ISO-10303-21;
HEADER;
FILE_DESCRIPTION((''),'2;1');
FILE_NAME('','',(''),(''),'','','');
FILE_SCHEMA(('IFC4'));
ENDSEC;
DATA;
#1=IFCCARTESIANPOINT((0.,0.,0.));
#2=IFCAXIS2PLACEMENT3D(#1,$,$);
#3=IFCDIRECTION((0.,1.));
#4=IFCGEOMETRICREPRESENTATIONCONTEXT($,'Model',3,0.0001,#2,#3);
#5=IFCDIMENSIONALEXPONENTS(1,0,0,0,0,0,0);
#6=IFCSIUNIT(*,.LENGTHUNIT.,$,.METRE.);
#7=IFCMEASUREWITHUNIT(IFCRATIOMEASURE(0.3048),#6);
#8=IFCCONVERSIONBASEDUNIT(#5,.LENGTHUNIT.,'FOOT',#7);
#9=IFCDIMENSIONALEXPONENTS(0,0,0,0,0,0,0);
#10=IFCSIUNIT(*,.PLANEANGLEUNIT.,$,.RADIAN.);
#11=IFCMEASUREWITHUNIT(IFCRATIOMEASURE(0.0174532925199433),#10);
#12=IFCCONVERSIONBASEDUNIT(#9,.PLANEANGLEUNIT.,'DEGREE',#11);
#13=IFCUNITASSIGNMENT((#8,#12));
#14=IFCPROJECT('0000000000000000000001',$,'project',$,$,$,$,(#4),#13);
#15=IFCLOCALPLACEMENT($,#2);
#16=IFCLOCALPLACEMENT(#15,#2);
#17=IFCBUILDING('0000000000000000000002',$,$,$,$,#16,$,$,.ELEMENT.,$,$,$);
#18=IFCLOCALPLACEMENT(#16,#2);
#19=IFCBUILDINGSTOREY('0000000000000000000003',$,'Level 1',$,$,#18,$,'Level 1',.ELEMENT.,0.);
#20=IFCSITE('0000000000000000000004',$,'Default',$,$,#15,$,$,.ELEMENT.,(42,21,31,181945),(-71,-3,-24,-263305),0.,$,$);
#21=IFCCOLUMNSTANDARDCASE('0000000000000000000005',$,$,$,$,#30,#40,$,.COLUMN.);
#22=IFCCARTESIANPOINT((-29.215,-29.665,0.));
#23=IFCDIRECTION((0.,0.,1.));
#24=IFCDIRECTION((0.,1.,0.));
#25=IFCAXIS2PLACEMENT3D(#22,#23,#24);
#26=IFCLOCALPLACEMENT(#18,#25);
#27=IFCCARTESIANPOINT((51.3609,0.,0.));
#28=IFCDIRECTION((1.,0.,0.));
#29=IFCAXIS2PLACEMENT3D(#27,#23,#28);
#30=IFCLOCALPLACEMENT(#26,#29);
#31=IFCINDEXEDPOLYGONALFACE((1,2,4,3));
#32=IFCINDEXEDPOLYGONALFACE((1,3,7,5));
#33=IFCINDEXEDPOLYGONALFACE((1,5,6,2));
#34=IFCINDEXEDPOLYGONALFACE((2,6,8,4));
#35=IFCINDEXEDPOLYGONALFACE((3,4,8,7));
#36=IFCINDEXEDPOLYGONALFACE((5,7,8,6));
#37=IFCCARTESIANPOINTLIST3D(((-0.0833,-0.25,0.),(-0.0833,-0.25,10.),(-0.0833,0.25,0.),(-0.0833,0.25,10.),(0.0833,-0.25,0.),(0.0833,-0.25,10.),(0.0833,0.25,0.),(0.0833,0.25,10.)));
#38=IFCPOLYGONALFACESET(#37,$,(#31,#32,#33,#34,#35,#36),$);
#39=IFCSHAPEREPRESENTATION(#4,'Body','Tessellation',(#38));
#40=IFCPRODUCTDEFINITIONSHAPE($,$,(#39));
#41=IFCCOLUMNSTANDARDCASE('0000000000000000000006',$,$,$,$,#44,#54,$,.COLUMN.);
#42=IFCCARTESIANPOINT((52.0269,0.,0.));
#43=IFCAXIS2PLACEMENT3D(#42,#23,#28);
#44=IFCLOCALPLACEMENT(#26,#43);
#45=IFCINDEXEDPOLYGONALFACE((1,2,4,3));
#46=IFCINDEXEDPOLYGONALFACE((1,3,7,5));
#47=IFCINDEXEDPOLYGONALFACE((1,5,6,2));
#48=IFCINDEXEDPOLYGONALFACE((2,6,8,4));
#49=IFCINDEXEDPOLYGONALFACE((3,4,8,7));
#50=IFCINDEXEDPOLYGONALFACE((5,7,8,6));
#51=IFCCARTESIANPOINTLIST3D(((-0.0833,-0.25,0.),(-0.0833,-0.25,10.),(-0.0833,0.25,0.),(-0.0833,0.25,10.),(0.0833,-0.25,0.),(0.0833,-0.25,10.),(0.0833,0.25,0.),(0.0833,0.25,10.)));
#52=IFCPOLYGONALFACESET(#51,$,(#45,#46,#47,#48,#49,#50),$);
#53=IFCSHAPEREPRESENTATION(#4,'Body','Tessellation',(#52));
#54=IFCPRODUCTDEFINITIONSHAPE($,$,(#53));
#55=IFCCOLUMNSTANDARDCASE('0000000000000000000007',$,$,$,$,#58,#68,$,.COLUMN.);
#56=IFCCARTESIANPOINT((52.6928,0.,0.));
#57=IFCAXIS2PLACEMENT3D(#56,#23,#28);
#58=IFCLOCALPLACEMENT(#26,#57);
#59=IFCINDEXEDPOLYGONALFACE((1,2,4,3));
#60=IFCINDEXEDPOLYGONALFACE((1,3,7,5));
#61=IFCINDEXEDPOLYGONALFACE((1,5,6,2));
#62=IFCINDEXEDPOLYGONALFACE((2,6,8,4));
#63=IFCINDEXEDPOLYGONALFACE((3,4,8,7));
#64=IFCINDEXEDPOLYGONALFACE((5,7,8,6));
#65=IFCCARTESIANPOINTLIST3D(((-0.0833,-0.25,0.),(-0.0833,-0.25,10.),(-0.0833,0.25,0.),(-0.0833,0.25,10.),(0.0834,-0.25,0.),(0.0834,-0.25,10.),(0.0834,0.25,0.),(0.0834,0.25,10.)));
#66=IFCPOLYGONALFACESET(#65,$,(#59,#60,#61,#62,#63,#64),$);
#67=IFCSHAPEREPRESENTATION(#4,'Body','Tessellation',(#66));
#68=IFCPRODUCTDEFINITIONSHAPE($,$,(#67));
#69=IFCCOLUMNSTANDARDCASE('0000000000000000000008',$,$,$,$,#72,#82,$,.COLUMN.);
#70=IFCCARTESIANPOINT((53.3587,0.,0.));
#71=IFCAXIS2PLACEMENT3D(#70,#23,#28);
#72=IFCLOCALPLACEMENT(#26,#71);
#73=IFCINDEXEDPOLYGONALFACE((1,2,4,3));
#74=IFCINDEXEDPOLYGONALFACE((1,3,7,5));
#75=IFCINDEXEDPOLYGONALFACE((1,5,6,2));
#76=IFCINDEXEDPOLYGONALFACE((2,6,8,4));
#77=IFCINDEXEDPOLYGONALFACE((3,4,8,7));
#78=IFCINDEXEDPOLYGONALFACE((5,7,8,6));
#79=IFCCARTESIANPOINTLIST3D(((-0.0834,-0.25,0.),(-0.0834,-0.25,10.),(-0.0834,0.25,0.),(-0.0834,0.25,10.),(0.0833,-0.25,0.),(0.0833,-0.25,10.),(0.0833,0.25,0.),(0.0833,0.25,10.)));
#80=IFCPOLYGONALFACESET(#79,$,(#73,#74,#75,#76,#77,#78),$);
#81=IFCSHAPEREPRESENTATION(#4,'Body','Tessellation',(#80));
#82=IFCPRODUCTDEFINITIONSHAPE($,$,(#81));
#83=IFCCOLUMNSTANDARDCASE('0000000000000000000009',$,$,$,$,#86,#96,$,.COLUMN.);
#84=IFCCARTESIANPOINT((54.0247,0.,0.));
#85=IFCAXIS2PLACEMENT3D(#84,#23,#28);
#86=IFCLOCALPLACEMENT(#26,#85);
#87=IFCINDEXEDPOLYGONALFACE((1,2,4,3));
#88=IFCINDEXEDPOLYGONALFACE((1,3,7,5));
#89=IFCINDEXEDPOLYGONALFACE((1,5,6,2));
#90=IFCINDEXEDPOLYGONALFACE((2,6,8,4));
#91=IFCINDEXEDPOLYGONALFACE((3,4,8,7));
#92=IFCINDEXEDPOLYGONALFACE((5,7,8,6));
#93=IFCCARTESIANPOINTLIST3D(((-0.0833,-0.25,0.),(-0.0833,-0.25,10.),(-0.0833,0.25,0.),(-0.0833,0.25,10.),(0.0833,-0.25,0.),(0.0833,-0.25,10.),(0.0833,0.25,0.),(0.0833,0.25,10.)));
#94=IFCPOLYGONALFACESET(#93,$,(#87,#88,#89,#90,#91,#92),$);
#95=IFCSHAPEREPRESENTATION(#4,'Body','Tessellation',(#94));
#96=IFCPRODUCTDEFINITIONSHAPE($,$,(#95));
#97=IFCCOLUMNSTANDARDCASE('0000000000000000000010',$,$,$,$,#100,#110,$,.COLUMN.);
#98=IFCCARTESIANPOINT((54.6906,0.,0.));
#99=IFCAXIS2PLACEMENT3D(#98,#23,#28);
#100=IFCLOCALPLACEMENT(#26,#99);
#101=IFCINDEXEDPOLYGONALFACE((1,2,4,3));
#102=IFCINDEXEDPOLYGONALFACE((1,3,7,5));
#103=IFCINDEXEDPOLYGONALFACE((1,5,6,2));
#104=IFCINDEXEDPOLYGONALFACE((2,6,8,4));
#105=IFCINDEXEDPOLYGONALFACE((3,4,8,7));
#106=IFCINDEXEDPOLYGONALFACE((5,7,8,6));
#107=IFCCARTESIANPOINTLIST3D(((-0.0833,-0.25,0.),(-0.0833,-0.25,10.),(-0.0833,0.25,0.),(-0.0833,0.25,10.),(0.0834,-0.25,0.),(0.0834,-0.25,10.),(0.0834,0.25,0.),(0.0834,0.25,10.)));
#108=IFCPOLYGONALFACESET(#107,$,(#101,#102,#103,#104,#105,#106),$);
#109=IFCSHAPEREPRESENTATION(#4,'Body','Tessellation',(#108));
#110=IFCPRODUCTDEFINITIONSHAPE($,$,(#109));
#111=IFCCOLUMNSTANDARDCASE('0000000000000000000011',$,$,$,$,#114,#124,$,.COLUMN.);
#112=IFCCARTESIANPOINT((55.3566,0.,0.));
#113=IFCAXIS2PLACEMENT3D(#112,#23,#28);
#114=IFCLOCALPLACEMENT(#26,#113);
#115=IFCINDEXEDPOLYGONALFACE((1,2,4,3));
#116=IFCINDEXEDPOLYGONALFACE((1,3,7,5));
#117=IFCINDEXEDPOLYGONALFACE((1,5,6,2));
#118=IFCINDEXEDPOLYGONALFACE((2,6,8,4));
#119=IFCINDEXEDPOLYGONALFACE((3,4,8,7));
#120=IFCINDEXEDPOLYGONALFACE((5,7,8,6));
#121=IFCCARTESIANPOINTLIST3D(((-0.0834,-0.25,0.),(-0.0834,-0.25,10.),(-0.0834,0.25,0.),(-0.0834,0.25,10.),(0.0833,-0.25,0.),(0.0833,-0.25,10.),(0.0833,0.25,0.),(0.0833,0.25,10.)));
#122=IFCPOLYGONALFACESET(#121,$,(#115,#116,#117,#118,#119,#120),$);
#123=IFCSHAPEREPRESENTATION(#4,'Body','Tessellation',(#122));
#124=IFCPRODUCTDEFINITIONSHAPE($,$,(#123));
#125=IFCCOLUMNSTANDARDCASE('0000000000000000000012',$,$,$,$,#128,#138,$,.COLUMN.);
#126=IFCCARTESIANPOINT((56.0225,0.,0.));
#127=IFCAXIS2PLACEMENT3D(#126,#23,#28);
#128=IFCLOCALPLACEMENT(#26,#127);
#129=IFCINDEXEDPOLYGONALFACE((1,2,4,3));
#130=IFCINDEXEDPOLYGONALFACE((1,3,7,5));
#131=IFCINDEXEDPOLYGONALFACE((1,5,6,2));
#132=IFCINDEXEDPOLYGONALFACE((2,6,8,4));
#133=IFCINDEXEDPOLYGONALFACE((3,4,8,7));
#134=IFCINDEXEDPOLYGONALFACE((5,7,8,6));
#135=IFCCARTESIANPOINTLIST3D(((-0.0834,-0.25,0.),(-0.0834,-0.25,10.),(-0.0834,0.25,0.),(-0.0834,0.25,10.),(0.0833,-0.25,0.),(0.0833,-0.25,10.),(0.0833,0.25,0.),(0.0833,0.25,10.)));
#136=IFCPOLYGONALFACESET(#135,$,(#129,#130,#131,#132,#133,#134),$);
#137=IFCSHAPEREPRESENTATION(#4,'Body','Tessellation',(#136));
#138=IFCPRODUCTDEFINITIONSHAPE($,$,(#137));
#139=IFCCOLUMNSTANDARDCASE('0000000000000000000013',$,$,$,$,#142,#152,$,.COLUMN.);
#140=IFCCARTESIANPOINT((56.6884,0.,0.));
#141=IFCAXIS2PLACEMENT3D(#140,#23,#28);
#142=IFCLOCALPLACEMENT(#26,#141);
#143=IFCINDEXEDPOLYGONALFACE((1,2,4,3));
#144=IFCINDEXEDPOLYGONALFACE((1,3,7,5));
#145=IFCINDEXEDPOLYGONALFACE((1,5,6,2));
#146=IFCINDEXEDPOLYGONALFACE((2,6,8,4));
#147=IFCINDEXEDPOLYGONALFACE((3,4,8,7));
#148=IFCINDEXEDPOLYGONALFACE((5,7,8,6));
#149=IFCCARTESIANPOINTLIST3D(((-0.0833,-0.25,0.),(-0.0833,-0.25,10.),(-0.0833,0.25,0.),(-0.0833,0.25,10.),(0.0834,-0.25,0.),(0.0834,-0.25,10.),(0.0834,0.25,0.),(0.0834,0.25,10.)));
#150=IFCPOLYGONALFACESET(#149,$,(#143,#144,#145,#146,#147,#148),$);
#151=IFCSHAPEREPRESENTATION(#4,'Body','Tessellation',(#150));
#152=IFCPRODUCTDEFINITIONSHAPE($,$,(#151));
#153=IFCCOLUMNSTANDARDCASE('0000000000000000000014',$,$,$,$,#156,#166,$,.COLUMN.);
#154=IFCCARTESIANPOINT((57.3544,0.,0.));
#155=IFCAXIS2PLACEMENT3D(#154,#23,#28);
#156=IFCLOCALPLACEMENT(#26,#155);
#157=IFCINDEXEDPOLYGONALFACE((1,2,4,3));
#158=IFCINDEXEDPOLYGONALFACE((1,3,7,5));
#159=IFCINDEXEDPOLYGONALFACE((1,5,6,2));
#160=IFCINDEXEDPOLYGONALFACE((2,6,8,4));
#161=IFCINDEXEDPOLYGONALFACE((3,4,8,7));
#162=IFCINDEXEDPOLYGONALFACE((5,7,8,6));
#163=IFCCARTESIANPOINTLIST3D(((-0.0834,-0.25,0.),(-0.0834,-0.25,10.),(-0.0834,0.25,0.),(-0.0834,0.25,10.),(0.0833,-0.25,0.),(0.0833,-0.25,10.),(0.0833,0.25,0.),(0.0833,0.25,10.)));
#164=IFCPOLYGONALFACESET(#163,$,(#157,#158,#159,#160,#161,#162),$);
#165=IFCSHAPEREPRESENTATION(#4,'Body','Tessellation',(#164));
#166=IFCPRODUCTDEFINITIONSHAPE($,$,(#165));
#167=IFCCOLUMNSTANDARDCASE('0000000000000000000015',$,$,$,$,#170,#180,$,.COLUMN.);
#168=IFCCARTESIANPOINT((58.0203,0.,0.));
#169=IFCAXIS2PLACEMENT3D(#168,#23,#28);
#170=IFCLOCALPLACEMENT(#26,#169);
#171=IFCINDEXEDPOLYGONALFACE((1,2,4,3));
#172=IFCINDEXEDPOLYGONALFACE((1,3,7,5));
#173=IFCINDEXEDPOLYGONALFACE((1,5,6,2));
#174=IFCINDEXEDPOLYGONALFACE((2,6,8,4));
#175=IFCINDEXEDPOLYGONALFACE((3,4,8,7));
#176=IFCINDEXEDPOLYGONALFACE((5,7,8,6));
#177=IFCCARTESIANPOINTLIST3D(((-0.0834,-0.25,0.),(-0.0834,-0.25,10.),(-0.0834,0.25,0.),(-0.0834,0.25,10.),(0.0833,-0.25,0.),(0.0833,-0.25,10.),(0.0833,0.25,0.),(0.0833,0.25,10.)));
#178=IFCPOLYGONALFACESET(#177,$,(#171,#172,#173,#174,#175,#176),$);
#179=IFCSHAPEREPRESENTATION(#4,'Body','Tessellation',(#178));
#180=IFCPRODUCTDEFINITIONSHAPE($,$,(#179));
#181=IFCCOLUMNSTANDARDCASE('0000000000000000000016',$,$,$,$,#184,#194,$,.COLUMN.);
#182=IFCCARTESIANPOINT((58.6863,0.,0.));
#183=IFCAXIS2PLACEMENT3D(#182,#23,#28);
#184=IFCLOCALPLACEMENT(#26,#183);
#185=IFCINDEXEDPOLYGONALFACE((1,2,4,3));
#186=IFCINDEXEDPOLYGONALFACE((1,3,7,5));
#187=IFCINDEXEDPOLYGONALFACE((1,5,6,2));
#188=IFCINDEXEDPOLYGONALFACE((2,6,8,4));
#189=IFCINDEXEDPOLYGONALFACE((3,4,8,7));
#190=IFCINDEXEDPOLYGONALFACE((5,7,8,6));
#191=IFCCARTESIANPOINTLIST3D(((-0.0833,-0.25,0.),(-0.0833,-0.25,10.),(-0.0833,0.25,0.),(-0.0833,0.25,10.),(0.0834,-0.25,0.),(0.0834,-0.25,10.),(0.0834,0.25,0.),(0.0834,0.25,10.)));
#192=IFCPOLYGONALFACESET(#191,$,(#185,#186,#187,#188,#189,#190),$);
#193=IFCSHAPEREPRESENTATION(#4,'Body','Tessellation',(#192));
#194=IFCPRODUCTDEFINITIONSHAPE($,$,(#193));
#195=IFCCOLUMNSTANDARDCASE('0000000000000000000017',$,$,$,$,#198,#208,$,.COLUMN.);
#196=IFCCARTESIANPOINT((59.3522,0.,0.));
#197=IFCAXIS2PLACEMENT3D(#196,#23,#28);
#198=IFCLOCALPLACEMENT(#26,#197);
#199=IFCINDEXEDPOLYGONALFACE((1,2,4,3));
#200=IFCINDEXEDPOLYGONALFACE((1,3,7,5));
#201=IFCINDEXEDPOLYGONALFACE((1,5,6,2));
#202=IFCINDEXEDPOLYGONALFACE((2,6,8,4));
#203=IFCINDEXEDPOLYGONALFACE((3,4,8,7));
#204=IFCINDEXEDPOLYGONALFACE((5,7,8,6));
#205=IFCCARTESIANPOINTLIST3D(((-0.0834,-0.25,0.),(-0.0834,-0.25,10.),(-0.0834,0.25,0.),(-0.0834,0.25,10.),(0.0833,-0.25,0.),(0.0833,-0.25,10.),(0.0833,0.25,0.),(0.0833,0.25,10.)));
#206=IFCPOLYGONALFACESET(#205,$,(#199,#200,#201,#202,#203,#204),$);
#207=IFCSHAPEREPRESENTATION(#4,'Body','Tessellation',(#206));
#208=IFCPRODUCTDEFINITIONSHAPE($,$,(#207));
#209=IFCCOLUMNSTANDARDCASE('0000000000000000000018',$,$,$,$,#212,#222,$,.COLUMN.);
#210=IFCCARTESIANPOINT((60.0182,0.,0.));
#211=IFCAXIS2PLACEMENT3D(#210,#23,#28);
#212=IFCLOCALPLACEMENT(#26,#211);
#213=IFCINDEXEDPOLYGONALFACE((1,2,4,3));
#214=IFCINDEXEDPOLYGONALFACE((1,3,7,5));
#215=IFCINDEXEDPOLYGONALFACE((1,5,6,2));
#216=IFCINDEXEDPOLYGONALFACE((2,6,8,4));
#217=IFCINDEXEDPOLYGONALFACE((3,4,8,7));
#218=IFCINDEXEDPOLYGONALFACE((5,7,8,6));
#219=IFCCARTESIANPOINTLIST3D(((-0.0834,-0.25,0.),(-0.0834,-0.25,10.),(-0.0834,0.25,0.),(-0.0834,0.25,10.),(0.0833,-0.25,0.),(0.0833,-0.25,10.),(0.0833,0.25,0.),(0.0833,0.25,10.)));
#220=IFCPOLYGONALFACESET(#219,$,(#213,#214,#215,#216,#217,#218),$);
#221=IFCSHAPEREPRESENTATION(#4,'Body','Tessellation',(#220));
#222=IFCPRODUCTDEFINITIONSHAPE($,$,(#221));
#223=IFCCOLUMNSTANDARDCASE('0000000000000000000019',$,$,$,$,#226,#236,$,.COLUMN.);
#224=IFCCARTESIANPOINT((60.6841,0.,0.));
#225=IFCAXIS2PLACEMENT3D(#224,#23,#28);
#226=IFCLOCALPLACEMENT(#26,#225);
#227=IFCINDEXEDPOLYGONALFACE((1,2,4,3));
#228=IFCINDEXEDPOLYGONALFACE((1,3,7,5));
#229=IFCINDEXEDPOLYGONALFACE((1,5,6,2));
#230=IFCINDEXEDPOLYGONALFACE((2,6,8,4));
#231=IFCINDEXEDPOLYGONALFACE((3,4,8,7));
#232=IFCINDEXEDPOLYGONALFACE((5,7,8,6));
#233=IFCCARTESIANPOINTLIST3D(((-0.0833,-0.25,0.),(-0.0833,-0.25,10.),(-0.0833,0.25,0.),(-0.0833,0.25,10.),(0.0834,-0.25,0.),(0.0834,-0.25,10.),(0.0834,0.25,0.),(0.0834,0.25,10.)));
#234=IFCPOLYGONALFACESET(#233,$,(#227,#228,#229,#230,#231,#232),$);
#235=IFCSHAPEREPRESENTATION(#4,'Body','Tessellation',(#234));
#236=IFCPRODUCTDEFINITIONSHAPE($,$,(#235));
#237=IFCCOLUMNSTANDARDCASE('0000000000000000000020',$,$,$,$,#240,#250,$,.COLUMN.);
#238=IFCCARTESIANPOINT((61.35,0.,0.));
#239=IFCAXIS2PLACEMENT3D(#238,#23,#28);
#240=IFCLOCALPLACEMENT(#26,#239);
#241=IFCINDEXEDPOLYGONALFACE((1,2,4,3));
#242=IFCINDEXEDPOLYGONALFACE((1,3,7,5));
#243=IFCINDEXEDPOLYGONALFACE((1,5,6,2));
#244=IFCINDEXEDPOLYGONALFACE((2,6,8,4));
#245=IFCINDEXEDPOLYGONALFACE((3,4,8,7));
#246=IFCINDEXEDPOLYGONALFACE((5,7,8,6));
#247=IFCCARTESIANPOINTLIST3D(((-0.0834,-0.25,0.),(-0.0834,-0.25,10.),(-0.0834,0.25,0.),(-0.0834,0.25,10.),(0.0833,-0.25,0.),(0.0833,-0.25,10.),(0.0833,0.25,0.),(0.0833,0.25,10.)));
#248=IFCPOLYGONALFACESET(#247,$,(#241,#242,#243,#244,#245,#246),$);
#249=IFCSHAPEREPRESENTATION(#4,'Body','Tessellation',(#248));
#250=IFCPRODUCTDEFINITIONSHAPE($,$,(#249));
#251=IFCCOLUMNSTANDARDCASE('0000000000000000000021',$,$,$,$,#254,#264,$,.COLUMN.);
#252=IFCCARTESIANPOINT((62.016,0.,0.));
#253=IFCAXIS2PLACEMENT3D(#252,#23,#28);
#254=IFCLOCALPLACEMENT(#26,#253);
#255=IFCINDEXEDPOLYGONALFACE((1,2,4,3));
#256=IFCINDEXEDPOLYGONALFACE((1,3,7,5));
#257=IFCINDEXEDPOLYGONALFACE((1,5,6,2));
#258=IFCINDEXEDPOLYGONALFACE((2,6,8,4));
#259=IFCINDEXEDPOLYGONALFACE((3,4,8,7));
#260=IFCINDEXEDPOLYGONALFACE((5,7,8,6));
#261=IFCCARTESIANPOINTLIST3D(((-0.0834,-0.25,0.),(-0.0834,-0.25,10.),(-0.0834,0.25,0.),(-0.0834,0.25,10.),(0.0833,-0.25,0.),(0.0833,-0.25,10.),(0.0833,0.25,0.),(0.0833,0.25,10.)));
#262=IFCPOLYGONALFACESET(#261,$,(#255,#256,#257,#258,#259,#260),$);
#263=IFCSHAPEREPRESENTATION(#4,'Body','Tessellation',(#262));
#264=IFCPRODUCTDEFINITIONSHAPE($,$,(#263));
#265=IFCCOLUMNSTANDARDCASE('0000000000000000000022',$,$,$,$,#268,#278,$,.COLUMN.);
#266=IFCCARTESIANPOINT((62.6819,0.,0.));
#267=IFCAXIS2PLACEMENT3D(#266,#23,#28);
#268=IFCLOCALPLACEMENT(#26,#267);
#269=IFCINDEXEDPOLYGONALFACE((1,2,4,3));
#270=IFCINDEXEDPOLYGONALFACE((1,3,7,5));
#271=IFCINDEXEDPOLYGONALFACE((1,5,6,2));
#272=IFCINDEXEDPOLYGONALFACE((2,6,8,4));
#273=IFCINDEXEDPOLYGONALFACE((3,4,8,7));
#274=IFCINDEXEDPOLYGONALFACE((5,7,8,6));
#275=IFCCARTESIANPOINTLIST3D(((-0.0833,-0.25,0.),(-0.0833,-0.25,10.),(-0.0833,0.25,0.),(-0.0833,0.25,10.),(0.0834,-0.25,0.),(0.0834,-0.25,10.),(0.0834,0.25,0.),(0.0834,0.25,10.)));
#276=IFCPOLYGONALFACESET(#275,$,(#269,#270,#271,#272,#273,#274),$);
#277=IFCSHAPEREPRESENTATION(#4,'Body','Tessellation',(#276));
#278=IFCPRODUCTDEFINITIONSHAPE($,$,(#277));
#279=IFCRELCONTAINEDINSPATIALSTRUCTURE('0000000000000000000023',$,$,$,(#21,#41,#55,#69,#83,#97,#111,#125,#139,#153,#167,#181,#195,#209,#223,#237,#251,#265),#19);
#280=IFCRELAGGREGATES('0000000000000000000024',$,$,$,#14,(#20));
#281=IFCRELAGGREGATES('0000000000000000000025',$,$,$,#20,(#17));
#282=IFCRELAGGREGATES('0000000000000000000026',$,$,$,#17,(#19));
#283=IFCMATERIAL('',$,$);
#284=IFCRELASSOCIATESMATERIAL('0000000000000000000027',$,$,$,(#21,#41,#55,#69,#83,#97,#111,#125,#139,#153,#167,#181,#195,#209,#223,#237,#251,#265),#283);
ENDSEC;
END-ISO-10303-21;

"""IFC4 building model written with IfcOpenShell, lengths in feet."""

from ifc_helpers import new_model, entity, si_unit, converted_unit, direction, frame, origin, place, context, project, spatial, rectangle, extrude, material, element, save


model = new_model("IFC4")

# Units and contexts
model_context = context("Model", 3, precision=0.0001, world=origin(), true_north=direction((0.0, 1.0)))
ifc_project = project(units=[converted_unit("LENGTHUNIT", "FOOT", entity("IfcRatioMeasure", 0.3048), si_unit("LENGTHUNIT", "METRE"), dimensions=[1, 0, 0, 0, 0, 0, 0]), converted_unit("PLANEANGLEUNIT", "DEGREE", entity("IfcRatioMeasure", 0.0174532925199433), si_unit("PLANEANGLEUNIT", "RADIAN"), dimensions=[0, 0, 0, 0, 0, 0, 0])], contexts=[model_context])

# Site, building, storey
site_placement = place(None, origin())
site = spatial("IfcSite", under=ifc_project, at=site_placement, Name="Default", CompositionType="ELEMENT", RefLatitude=(42, 21, 31, 181945), RefLongitude=(-71, -3, -24, -263305), RefElevation=0.0)
building_placement = place(site_placement, origin())
building = spatial("IfcBuilding", under=site, at=building_placement, CompositionType="ELEMENT")
storey_placement = place(building_placement, origin())
storey = spatial("IfcBuildingStorey", under=building, at=storey_placement, Name="Level 1", LongName="Level 1", CompositionType="ELEMENT", Elevation=0.0)

# Columns
ifc_material = material(Name="")
placement = place(storey_placement, frame((-29.215, -29.665, 0.0), z_axis=(0.0, 0.0, 1.0), x_axis=(0.0, 1.0, 0.0)))
for number, where, z_axis, x_axis in (
    (1, (51.3609, 0.0, 0.0), (0.0, 0.0, 1.0), (1.0, 0.0, 0.0)),
    (2, (52.0269, 0.0, 0.0), (0.0, 0.0, 1.0), (1.0, 0.0, 0.0)),
    (3, (52.6928, 0.0, 0.0), (0.0, 0.0, 1.0), (1.0, 0.0, 0.0)),
    (4, (53.3587, 0.0, 0.0), (0.0, 0.0, 1.0), (1.0, 0.0, 0.0)),
    (5, (54.0247, 0.0, 0.0), (0.0, 0.0, 1.0), (1.0, 0.0, 0.0)),
    (6, (54.6906, 0.0, 0.0), (0.0, 0.0, 1.0), (1.0, 0.0, 0.0)),
    (7, (55.3566, 0.0, 0.0), (0.0, 0.0, 1.0), (1.0, 0.0, 0.0)),
    (8, (56.0225, 0.0, 0.0), (0.0, 0.0, 1.0), (1.0, 0.0, 0.0)),
    (9, (56.6884, 0.0, 0.0), (0.0, 0.0, 1.0), (1.0, 0.0, 0.0)),
    (10, (57.3544, 0.0, 0.0), (0.0, 0.0, 1.0), (1.0, 0.0, 0.0)),
    (11, (58.0203, 0.0, 0.0), (0.0, 0.0, 1.0), (1.0, 0.0, 0.0)),
    (12, (58.6863, 0.0, 0.0), (0.0, 0.0, 1.0), (1.0, 0.0, 0.0)),
    (13, (59.3522, 0.0, 0.0), (0.0, 0.0, 1.0), (1.0, 0.0, 0.0)),
    (14, (60.0182, 0.0, 0.0), (0.0, 0.0, 1.0), (1.0, 0.0, 0.0)),
    (15, (60.6841, 0.0, 0.0), (0.0, 0.0, 1.0), (1.0, 0.0, 0.0)),
    (16, (61.35, 0.0, 0.0), (0.0, 0.0, 1.0), (1.0, 0.0, 0.0)),
    (17, (62.016, 0.0, 0.0), (0.0, 0.0, 1.0), (1.0, 0.0, 0.0)),
    (18, (62.6819, 0.0, 0.0), (0.0, 0.0, 1.0), (1.0, 0.0, 0.0)),
):
    element("IfcColumnStandardCase", number, at=place(placement, frame(where, z_axis=z_axis, x_axis=x_axis)), inside=storey, material=ifc_material, PredefinedType="COLUMN", context=model_context, shape_type="SweptSolid", body=[
        extrude(rectangle(XDim=0.1667, YDim=0.5), origin(), (0.0, 0.0, 1.0), 10.0),
    ])

save(model, "model.ifc")
